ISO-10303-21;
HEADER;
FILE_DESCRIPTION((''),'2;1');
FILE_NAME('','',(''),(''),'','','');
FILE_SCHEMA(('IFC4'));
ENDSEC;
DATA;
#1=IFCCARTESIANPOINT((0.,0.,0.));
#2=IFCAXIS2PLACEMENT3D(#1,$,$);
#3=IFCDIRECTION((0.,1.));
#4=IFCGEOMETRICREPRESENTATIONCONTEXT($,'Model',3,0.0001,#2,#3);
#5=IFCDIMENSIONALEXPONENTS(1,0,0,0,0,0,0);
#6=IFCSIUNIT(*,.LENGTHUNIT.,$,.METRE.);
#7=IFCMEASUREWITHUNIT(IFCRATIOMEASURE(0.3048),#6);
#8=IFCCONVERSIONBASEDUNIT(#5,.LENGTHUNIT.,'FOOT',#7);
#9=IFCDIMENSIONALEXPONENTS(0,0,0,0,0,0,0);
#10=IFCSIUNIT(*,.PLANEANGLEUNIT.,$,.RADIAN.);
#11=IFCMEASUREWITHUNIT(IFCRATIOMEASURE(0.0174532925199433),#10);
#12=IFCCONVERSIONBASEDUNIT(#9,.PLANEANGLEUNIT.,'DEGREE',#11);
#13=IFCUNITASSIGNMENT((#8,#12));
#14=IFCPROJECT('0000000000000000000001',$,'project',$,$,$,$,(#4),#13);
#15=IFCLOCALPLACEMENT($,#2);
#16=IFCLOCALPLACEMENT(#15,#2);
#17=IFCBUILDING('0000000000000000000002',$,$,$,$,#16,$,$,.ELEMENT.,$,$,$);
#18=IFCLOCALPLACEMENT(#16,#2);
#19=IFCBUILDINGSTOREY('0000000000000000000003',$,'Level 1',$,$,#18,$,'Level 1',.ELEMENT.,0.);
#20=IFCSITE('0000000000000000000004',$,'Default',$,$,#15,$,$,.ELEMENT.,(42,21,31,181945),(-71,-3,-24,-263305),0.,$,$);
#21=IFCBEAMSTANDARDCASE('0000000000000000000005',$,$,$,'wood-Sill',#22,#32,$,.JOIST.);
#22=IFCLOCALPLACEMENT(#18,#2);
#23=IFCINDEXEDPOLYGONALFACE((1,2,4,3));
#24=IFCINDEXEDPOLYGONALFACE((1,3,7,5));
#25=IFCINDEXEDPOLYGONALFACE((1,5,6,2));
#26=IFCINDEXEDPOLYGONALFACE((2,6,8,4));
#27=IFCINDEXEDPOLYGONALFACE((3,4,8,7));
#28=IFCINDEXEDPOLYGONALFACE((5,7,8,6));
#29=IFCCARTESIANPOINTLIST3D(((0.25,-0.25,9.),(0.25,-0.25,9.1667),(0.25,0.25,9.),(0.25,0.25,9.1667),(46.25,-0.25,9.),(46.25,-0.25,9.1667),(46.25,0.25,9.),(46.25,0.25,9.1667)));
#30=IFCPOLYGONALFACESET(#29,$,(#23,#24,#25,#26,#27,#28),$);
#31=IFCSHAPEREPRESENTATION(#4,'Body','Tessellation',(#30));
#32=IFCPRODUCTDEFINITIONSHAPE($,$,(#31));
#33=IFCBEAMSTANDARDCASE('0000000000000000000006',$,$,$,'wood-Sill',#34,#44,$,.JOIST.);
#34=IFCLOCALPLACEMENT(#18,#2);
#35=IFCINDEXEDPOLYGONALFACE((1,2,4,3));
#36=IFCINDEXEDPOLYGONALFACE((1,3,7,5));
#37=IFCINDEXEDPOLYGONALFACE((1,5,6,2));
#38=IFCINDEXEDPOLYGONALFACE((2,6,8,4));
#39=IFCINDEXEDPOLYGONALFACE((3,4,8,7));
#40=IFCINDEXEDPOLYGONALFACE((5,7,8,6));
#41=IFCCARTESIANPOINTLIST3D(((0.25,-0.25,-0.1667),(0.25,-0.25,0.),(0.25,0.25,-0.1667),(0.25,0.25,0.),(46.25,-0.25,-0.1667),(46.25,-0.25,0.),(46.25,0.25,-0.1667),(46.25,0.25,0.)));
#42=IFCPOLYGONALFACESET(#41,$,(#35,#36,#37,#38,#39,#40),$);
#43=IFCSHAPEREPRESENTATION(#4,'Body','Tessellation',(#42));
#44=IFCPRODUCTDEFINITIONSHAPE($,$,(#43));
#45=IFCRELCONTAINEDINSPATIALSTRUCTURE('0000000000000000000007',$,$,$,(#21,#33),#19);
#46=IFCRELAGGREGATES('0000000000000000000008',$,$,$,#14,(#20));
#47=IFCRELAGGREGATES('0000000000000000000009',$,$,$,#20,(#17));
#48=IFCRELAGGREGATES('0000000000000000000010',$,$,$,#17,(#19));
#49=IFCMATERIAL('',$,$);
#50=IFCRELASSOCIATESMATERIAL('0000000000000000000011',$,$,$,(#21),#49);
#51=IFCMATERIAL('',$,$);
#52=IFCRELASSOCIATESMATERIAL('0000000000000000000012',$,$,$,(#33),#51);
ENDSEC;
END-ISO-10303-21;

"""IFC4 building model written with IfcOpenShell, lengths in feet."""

from ifc_helpers import new_model, entity, si_unit, converted_unit, direction, frame, origin, place, context, project, spatial, rectangle, extrude, material, element, save


model = new_model("IFC4")

# Units and contexts
model_context = context("Model", 3, precision=0.0001, world=origin(), true_north=direction((0.0, 1.0)))
ifc_project = project(units=[converted_unit("LENGTHUNIT", "FOOT", entity("IfcRatioMeasure", 0.3048), si_unit("LENGTHUNIT", "METRE"), dimensions=[1, 0, 0, 0, 0, 0, 0]), converted_unit("PLANEANGLEUNIT", "DEGREE", entity("IfcRatioMeasure", 0.0174532925199433), si_unit("PLANEANGLEUNIT", "RADIAN"), dimensions=[0, 0, 0, 0, 0, 0, 0])], contexts=[model_context])

# Site, building, storey
site_placement = place(None, origin())
site = spatial("IfcSite", under=ifc_project, at=site_placement, Name="Default", CompositionType="ELEMENT", RefLatitude=(42, 21, 31, 181945), RefLongitude=(-71, -3, -24, -263305), RefElevation=0.0)
building_placement = place(site_placement, origin())
building = spatial("IfcBuilding", under=site, at=building_placement, CompositionType="ELEMENT")
storey_placement = place(building_placement, origin())
storey = spatial("IfcBuildingStorey", under=building, at=storey_placement, Name="Level 1", LongName="Level 1", CompositionType="ELEMENT", Elevation=0.0)

# Shared definitions
placement = place(storey_placement, frame((46.25, 0.0, 0.0), z_axis=(0.0, 0.0, 1.0), x_axis=(-1.0, 0.0, 0.0)))

# Beams
ifc_material_1 = material(Name="")
beam_1_placement = place(placement, frame((23.0, 0.0, 9.0), z_axis=(0.0, 0.0, 1.0), x_axis=(-1.0, 0.0, 0.0)))
element("IfcBeamStandardCase", 1, at=beam_1_placement, inside=storey, material=ifc_material_1, ObjectType="wood-Sill", PredefinedType="JOIST", context=model_context, shape_type="SweptSolid", body=[
    extrude(rectangle(XDim=46.0, YDim=0.5), origin(), (0.0, 0.0, 1.0), 0.1667),
])
ifc_material_2 = material(Name="")
beam_2_placement = place(placement, frame((23.0, 0.0, -0.1667), z_axis=(0.0, 0.0, 1.0), x_axis=(-1.0, 0.0, 0.0)))
element("IfcBeamStandardCase", 2, at=beam_2_placement, inside=storey, material=ifc_material_2, ObjectType="wood-Sill", PredefinedType="JOIST", context=model_context, shape_type="SweptSolid", body=[
    extrude(rectangle(XDim=46.0, YDim=0.5), origin(), (0.0, 0.0, 1.0), 0.1667),
])

save(model, "model.ifc")
